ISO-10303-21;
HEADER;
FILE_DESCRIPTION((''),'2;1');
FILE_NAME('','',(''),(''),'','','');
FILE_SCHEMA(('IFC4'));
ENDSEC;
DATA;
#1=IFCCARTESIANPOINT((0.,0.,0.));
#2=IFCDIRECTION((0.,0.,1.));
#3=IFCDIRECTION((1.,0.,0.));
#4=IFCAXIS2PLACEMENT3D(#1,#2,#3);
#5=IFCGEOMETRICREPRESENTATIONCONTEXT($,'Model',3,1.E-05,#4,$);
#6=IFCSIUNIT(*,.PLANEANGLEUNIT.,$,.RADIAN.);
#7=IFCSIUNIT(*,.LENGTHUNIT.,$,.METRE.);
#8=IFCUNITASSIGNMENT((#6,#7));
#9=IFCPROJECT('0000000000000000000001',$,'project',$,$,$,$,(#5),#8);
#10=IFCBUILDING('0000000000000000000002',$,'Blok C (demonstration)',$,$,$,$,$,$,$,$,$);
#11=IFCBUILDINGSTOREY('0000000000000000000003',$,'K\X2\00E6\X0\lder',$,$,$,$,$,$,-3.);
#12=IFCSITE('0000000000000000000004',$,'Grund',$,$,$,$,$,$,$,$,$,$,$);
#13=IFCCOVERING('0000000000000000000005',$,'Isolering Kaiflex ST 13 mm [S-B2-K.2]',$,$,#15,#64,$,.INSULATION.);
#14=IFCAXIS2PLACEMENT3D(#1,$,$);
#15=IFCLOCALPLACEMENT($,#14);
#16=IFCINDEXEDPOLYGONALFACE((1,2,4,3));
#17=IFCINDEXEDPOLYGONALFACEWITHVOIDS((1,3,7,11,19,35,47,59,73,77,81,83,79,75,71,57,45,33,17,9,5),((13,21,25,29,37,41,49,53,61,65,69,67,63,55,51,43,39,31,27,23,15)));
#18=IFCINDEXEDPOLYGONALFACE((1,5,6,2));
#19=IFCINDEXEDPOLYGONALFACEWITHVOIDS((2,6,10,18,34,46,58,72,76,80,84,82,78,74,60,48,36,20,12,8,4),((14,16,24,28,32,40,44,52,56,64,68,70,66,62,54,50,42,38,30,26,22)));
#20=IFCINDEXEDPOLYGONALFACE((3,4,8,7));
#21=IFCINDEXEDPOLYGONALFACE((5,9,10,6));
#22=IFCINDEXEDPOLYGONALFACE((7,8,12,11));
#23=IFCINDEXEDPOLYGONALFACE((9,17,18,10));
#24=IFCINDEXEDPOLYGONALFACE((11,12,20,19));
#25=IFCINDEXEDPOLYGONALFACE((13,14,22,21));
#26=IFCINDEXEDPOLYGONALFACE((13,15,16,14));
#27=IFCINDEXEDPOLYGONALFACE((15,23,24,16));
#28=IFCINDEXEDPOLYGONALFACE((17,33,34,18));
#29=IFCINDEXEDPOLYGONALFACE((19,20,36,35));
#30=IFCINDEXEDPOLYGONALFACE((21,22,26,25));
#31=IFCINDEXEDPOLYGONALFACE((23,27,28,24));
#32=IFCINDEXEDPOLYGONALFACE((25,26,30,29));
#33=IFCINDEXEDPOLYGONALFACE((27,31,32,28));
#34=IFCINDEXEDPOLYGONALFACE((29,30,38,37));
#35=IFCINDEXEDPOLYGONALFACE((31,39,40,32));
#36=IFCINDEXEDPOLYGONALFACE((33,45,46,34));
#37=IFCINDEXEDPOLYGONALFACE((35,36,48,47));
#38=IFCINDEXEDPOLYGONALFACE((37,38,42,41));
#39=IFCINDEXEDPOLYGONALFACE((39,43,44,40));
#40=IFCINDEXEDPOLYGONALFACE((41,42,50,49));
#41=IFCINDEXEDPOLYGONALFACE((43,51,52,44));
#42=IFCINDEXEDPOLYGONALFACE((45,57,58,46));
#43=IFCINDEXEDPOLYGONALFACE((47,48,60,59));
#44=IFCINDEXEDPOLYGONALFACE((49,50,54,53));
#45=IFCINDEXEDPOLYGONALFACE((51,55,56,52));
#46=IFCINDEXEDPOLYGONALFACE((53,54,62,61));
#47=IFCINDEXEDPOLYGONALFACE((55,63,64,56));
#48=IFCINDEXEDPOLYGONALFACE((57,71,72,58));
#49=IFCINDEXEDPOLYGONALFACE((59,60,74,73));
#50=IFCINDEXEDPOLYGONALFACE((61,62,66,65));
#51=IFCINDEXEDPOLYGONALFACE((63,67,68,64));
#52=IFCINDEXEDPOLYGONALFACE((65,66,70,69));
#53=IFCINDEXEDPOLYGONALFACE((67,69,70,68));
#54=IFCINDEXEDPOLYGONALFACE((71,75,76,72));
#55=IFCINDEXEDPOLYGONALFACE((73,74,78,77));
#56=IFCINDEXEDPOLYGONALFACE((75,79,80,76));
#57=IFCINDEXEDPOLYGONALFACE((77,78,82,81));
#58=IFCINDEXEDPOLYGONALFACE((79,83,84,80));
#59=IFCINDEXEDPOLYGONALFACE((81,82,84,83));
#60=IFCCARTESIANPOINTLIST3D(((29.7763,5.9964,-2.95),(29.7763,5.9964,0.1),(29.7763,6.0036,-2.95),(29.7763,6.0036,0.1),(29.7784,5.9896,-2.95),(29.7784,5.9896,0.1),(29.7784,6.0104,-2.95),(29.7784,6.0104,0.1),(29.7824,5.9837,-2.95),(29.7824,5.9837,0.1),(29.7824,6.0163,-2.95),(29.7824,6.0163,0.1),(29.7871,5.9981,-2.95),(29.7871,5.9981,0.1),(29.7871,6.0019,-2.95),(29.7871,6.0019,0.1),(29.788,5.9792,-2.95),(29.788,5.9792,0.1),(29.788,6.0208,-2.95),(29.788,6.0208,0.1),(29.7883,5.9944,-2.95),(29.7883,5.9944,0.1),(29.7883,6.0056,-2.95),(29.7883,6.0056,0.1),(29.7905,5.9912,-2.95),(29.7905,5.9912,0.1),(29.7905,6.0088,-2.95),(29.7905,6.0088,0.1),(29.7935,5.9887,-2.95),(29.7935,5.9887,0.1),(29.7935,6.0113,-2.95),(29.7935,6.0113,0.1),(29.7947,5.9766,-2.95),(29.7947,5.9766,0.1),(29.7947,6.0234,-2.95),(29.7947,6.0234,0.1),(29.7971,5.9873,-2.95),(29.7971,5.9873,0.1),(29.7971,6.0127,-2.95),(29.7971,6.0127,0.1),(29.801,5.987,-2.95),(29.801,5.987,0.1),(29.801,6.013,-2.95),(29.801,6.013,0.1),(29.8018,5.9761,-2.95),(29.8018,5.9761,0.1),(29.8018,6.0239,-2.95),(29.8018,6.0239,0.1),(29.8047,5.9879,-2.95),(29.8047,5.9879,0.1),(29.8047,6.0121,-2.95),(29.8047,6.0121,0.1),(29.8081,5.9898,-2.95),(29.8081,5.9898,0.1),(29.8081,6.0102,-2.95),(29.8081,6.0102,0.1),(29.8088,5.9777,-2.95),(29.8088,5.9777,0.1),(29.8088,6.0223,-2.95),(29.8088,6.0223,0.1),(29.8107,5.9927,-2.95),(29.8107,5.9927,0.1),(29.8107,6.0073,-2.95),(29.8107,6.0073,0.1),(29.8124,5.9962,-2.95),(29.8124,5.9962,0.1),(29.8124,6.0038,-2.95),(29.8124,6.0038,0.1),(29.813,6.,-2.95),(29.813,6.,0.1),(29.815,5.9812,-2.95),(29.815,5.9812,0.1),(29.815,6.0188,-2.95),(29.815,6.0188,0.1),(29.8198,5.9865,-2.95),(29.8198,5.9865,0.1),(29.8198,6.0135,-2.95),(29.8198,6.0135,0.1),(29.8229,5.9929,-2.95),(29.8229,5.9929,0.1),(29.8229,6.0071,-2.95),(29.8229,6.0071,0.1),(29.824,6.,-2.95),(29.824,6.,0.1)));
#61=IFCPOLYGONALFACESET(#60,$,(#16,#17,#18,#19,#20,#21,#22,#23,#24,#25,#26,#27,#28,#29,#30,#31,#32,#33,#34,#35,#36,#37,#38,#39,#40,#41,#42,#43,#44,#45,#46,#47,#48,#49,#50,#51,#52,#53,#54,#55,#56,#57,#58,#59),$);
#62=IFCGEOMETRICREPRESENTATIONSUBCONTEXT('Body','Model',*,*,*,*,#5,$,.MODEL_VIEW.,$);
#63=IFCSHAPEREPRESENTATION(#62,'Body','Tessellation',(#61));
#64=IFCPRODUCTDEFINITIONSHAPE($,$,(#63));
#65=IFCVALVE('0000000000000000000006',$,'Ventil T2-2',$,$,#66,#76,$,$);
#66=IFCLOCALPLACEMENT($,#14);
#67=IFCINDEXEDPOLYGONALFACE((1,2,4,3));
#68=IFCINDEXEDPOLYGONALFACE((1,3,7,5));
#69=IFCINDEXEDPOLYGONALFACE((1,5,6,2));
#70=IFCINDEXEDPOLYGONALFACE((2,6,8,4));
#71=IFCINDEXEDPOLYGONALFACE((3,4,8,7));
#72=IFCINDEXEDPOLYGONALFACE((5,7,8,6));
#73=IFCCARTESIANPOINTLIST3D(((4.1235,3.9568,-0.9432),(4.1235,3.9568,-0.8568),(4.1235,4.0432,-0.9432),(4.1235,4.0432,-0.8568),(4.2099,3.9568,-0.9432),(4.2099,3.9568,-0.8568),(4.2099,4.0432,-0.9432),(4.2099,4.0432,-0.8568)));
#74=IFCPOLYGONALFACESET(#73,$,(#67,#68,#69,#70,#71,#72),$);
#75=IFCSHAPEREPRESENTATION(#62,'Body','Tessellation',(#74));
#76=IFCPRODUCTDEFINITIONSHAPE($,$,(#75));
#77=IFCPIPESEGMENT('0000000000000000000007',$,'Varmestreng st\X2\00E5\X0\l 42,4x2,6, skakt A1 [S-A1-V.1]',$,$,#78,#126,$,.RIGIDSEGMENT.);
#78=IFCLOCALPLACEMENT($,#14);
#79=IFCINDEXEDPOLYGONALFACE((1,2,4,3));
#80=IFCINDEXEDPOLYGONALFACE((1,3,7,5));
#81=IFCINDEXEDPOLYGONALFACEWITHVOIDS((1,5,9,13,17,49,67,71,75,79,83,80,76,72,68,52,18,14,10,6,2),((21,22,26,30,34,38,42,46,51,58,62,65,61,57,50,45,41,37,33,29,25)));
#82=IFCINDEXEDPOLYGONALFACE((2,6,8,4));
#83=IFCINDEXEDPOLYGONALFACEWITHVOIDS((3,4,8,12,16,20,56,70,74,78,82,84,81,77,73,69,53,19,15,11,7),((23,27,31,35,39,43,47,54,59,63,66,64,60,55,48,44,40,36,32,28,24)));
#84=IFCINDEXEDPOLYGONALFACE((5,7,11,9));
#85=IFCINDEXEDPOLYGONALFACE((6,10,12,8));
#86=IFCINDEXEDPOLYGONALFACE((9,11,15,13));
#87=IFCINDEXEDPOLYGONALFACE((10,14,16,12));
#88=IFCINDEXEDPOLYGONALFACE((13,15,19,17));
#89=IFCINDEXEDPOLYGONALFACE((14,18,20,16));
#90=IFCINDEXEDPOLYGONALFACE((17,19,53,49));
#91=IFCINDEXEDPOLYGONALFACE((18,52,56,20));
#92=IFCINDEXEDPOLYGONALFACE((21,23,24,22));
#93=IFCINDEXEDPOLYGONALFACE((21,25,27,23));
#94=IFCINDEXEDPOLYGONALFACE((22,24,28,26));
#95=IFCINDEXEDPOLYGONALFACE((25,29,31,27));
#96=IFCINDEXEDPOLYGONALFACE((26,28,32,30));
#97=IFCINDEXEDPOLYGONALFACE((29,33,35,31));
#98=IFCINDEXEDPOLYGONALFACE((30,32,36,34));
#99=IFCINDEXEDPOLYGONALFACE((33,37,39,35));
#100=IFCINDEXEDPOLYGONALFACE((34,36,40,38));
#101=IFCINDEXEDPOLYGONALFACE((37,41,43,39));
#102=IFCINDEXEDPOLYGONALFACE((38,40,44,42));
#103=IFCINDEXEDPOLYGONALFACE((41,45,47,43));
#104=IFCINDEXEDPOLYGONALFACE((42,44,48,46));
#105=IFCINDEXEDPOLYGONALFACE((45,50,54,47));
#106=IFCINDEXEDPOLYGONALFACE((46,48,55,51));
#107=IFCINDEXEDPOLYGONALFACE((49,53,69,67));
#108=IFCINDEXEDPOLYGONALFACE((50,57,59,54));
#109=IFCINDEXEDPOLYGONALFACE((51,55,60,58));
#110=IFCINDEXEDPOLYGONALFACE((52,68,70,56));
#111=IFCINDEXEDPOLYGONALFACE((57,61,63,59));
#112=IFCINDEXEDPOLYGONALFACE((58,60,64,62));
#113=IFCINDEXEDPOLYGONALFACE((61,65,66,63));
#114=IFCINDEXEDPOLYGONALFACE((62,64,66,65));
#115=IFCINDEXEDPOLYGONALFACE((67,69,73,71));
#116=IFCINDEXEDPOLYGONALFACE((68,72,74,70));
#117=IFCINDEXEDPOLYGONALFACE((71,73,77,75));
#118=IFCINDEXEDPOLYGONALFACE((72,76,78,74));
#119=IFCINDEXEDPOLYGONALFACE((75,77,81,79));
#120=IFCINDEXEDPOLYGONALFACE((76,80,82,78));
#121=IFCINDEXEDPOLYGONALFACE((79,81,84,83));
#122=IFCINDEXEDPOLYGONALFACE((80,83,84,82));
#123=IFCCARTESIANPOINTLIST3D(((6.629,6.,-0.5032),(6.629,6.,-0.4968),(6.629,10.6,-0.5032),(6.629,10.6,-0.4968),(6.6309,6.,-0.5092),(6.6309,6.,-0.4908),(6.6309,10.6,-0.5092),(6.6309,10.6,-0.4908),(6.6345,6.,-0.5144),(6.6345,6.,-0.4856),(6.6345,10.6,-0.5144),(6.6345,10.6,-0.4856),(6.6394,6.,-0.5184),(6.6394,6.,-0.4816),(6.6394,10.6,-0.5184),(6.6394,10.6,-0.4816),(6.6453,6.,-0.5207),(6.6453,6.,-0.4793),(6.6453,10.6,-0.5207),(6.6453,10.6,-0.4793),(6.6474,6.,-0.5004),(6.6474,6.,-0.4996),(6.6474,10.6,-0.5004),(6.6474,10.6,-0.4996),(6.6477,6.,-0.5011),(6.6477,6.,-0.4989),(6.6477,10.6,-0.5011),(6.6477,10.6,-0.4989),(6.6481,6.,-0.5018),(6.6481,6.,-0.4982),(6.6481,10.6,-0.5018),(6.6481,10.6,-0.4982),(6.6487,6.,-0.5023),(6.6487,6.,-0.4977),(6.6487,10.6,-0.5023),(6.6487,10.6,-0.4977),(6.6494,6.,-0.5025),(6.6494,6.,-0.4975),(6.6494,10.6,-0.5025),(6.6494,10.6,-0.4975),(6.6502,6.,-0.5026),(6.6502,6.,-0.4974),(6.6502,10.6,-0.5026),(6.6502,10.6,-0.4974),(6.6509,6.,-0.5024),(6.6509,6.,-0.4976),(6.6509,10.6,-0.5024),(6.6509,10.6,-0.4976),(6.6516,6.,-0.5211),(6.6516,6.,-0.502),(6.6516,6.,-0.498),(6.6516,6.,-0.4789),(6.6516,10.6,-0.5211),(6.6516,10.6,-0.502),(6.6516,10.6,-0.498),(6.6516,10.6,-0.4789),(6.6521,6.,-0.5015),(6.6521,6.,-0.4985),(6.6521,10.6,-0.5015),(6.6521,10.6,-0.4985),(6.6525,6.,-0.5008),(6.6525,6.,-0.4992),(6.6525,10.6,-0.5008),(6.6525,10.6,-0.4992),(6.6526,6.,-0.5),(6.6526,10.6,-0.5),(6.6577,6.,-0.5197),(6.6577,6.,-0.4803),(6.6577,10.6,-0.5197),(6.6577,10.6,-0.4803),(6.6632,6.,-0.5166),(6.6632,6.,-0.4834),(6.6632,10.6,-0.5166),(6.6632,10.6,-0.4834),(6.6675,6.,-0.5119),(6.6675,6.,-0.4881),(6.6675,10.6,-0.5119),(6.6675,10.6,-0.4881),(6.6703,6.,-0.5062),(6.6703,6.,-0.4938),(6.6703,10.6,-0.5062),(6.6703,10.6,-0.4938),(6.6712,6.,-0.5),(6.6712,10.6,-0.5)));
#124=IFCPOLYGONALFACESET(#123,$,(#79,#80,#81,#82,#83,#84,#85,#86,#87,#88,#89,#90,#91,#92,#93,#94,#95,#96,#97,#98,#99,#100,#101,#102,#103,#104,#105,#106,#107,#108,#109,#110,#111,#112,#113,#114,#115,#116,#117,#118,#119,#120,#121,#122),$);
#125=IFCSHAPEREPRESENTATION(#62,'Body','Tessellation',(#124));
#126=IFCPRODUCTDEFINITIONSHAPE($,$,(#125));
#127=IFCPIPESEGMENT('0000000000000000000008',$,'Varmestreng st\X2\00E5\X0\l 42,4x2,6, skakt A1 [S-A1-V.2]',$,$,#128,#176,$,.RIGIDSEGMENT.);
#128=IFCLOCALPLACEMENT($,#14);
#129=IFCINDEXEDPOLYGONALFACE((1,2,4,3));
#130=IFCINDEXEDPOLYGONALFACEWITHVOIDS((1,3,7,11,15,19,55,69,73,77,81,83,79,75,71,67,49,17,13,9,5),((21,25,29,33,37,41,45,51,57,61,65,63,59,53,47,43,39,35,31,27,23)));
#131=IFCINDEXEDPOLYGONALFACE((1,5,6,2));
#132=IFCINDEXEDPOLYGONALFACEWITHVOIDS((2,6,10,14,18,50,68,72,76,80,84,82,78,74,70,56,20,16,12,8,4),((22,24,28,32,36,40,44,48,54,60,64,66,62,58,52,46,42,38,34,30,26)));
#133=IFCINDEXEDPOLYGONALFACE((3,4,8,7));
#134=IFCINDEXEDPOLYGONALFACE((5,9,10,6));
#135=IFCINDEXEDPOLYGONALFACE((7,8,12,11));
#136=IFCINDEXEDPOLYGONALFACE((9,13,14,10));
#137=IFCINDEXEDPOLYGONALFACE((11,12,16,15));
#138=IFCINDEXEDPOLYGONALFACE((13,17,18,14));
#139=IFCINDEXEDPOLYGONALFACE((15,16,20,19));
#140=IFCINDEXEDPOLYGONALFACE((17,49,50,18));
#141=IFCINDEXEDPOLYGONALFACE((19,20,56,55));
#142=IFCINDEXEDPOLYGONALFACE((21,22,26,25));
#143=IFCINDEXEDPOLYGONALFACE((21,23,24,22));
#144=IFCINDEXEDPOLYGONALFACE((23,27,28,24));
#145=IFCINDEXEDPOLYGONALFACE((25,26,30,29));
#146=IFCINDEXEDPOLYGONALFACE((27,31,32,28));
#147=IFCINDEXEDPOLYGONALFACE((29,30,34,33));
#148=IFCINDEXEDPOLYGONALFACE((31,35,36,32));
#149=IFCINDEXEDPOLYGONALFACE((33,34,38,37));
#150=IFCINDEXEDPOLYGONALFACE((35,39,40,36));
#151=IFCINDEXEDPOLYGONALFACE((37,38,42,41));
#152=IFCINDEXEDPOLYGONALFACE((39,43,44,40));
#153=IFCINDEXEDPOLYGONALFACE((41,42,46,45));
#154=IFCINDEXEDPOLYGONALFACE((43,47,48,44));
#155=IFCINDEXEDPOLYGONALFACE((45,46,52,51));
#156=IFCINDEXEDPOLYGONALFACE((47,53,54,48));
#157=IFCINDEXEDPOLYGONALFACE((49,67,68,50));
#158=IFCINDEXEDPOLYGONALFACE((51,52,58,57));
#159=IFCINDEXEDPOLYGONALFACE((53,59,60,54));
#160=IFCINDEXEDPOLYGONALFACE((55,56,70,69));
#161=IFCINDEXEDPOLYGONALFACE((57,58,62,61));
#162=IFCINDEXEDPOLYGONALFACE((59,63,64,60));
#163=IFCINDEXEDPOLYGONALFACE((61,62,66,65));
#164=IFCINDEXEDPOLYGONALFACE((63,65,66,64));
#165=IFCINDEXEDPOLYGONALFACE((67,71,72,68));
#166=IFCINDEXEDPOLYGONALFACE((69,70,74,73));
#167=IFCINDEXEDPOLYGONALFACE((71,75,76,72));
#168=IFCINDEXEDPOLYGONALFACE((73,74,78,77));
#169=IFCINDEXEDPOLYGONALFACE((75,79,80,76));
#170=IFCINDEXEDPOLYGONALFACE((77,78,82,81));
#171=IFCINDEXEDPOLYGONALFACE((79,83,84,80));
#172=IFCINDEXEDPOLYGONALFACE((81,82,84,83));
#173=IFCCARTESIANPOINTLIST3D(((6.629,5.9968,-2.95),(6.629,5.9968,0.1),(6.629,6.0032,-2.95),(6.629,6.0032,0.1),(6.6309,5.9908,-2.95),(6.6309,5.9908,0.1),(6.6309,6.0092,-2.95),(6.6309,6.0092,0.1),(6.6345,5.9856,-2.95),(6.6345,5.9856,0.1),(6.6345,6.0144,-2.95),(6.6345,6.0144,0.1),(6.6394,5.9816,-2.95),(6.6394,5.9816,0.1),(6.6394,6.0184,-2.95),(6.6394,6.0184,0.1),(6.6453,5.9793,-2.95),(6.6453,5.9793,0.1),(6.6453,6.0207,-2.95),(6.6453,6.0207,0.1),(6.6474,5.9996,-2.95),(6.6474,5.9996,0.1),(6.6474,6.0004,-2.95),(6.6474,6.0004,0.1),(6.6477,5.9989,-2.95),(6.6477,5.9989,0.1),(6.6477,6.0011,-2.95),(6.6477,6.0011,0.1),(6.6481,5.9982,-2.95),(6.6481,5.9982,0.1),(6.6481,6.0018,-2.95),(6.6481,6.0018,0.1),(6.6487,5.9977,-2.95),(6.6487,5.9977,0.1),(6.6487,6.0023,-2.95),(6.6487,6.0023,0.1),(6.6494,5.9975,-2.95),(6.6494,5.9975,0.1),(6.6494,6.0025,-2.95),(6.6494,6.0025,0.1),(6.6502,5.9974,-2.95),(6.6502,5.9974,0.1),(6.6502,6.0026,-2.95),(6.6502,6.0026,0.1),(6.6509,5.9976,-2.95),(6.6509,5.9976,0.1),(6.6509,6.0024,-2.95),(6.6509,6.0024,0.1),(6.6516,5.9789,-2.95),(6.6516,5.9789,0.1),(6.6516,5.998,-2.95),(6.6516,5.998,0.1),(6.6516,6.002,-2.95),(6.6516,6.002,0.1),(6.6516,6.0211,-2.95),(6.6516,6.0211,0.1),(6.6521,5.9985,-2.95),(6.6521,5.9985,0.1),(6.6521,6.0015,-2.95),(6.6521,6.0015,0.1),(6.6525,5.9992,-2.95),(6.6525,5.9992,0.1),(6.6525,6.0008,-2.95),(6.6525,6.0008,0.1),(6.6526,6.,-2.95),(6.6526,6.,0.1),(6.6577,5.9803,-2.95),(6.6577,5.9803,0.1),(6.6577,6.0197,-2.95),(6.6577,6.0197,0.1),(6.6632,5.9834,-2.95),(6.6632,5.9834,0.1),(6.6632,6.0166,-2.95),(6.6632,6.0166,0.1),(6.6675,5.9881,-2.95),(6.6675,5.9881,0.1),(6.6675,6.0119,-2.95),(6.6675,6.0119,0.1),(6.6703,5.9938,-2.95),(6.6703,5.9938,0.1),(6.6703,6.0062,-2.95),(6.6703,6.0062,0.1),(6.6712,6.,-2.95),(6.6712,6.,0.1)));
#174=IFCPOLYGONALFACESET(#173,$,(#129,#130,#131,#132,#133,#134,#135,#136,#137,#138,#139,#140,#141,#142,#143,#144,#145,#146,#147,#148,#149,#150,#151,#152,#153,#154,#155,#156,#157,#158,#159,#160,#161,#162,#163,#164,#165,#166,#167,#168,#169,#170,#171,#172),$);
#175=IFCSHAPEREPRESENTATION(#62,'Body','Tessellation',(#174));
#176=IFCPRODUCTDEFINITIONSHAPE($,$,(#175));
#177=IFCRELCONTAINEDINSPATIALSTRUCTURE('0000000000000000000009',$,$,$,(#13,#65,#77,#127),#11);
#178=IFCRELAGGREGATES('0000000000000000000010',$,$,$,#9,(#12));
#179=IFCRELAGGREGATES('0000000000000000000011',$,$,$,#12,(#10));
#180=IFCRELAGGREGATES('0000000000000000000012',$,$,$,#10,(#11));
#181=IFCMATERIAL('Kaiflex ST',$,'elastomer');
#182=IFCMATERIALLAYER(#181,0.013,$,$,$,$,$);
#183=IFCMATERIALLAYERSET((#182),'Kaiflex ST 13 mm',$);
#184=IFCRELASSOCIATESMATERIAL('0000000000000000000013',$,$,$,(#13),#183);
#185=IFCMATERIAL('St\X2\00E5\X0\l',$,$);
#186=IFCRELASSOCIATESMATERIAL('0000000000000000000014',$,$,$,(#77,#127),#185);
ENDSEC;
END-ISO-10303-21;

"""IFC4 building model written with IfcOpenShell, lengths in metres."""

from ifc_helpers import new_model, si_unit, frame, origin_with_axes, place, context, subcontext, project, spatial, polyline, hollow_circle, outline, extrude, material, layer, layer_set, element, save


model = new_model("IFC4")

# Units and contexts
model_context = context("Model", 3, precision=1e-05, world=origin_with_axes())
body_context = subcontext(model_context, "Body", "Model", "MODEL_VIEW")
ifc_project = project(units=[si_unit("PLANEANGLEUNIT", "RADIAN"), si_unit("LENGTHUNIT", "METRE")], contexts=[model_context])

# Site, building, storey
site = spatial("IfcSite", under=ifc_project, Name="Grund")
building = spatial("IfcBuilding", under=site, Name="Blok C (demonstration)")
storey = spatial("IfcBuildingStorey", under=building, Name="Kælder", Elevation=-3.0)

# Covering
ifc_material_1 = material(Name="Kaiflex ST", Category="elastomer")
ifc_layer_1 = layer(ifc_material_1, 0.013)
ifc_layer_set_1 = layer_set([ifc_layer_1], Name="Kaiflex ST 13 mm")
covering_1_placement = place(None, origin_with_axes())
element("IfcCovering", 1, at=covering_1_placement, inside=storey, material=ifc_layer_set_1, Name="Isolering Kaiflex ST 13 mm [S-B2-K.2]", PredefinedType="INSULATION", context=body_context, shape_type="SweptSolid", body=[
    extrude(hollow_circle(Radius=0.024, WallThickness=0.011), frame((29.8, 6.0, -2.95), z_axis=(0.0, 0.0, 1.0), x_axis=(1.0, 0.0, 0.0)), (0.0, 0.0, 1.0), 3.05),
])

# Valve
valve_placement = place(None, origin_with_axes())
element("IfcValve", 2, at=valve_placement, inside=storey, Name="Ventil T2-2", context=body_context, shape_type="SweptSolid", body=[
    extrude(outline(polyline([(4.1235, 3.9568), (4.2099, 3.9568), (4.2099, 4.0432), (4.1235, 4.0432), (4.1235, 3.9568)])), frame((0.0, 0.0, -0.9432)), (0.0, 0.0, 1.0), 0.0864),
])

# Pipe segments
ifc_material_2 = material(Name="Stål")
pipe_segment_1_placement = place(None, origin_with_axes())
element("IfcPipeSegment", 3, at=pipe_segment_1_placement, inside=storey, material=ifc_material_2, Name="Varmestreng stål 42,4x2,6, skakt A1 [S-A1-V.1]", PredefinedType="RIGIDSEGMENT", context=body_context, shape_type="SweptSolid", body=[
    extrude(hollow_circle(Radius=0.0212, WallThickness=0.0186), frame((6.65, 10.6, -0.5), z_axis=(0.0, -1.0, 0.0), x_axis=(1.0, 0.0, 0.0)), (0.0, 0.0, 1.0), 4.6),
])
pipe_segment_2_placement = place(None, origin_with_axes())
element("IfcPipeSegment", 4, at=pipe_segment_2_placement, inside=storey, material=ifc_material_2, Name="Varmestreng stål 42,4x2,6, skakt A1 [S-A1-V.2]", PredefinedType="RIGIDSEGMENT", context=body_context, shape_type="SweptSolid", body=[
    extrude(hollow_circle(Radius=0.0212, WallThickness=0.0186), frame((6.65, 6.0, -2.95), z_axis=(0.0, 0.0, 1.0), x_axis=(1.0, 0.0, 0.0)), (0.0, 0.0, 1.0), 3.05),
])

save(model, "model.ifc")
